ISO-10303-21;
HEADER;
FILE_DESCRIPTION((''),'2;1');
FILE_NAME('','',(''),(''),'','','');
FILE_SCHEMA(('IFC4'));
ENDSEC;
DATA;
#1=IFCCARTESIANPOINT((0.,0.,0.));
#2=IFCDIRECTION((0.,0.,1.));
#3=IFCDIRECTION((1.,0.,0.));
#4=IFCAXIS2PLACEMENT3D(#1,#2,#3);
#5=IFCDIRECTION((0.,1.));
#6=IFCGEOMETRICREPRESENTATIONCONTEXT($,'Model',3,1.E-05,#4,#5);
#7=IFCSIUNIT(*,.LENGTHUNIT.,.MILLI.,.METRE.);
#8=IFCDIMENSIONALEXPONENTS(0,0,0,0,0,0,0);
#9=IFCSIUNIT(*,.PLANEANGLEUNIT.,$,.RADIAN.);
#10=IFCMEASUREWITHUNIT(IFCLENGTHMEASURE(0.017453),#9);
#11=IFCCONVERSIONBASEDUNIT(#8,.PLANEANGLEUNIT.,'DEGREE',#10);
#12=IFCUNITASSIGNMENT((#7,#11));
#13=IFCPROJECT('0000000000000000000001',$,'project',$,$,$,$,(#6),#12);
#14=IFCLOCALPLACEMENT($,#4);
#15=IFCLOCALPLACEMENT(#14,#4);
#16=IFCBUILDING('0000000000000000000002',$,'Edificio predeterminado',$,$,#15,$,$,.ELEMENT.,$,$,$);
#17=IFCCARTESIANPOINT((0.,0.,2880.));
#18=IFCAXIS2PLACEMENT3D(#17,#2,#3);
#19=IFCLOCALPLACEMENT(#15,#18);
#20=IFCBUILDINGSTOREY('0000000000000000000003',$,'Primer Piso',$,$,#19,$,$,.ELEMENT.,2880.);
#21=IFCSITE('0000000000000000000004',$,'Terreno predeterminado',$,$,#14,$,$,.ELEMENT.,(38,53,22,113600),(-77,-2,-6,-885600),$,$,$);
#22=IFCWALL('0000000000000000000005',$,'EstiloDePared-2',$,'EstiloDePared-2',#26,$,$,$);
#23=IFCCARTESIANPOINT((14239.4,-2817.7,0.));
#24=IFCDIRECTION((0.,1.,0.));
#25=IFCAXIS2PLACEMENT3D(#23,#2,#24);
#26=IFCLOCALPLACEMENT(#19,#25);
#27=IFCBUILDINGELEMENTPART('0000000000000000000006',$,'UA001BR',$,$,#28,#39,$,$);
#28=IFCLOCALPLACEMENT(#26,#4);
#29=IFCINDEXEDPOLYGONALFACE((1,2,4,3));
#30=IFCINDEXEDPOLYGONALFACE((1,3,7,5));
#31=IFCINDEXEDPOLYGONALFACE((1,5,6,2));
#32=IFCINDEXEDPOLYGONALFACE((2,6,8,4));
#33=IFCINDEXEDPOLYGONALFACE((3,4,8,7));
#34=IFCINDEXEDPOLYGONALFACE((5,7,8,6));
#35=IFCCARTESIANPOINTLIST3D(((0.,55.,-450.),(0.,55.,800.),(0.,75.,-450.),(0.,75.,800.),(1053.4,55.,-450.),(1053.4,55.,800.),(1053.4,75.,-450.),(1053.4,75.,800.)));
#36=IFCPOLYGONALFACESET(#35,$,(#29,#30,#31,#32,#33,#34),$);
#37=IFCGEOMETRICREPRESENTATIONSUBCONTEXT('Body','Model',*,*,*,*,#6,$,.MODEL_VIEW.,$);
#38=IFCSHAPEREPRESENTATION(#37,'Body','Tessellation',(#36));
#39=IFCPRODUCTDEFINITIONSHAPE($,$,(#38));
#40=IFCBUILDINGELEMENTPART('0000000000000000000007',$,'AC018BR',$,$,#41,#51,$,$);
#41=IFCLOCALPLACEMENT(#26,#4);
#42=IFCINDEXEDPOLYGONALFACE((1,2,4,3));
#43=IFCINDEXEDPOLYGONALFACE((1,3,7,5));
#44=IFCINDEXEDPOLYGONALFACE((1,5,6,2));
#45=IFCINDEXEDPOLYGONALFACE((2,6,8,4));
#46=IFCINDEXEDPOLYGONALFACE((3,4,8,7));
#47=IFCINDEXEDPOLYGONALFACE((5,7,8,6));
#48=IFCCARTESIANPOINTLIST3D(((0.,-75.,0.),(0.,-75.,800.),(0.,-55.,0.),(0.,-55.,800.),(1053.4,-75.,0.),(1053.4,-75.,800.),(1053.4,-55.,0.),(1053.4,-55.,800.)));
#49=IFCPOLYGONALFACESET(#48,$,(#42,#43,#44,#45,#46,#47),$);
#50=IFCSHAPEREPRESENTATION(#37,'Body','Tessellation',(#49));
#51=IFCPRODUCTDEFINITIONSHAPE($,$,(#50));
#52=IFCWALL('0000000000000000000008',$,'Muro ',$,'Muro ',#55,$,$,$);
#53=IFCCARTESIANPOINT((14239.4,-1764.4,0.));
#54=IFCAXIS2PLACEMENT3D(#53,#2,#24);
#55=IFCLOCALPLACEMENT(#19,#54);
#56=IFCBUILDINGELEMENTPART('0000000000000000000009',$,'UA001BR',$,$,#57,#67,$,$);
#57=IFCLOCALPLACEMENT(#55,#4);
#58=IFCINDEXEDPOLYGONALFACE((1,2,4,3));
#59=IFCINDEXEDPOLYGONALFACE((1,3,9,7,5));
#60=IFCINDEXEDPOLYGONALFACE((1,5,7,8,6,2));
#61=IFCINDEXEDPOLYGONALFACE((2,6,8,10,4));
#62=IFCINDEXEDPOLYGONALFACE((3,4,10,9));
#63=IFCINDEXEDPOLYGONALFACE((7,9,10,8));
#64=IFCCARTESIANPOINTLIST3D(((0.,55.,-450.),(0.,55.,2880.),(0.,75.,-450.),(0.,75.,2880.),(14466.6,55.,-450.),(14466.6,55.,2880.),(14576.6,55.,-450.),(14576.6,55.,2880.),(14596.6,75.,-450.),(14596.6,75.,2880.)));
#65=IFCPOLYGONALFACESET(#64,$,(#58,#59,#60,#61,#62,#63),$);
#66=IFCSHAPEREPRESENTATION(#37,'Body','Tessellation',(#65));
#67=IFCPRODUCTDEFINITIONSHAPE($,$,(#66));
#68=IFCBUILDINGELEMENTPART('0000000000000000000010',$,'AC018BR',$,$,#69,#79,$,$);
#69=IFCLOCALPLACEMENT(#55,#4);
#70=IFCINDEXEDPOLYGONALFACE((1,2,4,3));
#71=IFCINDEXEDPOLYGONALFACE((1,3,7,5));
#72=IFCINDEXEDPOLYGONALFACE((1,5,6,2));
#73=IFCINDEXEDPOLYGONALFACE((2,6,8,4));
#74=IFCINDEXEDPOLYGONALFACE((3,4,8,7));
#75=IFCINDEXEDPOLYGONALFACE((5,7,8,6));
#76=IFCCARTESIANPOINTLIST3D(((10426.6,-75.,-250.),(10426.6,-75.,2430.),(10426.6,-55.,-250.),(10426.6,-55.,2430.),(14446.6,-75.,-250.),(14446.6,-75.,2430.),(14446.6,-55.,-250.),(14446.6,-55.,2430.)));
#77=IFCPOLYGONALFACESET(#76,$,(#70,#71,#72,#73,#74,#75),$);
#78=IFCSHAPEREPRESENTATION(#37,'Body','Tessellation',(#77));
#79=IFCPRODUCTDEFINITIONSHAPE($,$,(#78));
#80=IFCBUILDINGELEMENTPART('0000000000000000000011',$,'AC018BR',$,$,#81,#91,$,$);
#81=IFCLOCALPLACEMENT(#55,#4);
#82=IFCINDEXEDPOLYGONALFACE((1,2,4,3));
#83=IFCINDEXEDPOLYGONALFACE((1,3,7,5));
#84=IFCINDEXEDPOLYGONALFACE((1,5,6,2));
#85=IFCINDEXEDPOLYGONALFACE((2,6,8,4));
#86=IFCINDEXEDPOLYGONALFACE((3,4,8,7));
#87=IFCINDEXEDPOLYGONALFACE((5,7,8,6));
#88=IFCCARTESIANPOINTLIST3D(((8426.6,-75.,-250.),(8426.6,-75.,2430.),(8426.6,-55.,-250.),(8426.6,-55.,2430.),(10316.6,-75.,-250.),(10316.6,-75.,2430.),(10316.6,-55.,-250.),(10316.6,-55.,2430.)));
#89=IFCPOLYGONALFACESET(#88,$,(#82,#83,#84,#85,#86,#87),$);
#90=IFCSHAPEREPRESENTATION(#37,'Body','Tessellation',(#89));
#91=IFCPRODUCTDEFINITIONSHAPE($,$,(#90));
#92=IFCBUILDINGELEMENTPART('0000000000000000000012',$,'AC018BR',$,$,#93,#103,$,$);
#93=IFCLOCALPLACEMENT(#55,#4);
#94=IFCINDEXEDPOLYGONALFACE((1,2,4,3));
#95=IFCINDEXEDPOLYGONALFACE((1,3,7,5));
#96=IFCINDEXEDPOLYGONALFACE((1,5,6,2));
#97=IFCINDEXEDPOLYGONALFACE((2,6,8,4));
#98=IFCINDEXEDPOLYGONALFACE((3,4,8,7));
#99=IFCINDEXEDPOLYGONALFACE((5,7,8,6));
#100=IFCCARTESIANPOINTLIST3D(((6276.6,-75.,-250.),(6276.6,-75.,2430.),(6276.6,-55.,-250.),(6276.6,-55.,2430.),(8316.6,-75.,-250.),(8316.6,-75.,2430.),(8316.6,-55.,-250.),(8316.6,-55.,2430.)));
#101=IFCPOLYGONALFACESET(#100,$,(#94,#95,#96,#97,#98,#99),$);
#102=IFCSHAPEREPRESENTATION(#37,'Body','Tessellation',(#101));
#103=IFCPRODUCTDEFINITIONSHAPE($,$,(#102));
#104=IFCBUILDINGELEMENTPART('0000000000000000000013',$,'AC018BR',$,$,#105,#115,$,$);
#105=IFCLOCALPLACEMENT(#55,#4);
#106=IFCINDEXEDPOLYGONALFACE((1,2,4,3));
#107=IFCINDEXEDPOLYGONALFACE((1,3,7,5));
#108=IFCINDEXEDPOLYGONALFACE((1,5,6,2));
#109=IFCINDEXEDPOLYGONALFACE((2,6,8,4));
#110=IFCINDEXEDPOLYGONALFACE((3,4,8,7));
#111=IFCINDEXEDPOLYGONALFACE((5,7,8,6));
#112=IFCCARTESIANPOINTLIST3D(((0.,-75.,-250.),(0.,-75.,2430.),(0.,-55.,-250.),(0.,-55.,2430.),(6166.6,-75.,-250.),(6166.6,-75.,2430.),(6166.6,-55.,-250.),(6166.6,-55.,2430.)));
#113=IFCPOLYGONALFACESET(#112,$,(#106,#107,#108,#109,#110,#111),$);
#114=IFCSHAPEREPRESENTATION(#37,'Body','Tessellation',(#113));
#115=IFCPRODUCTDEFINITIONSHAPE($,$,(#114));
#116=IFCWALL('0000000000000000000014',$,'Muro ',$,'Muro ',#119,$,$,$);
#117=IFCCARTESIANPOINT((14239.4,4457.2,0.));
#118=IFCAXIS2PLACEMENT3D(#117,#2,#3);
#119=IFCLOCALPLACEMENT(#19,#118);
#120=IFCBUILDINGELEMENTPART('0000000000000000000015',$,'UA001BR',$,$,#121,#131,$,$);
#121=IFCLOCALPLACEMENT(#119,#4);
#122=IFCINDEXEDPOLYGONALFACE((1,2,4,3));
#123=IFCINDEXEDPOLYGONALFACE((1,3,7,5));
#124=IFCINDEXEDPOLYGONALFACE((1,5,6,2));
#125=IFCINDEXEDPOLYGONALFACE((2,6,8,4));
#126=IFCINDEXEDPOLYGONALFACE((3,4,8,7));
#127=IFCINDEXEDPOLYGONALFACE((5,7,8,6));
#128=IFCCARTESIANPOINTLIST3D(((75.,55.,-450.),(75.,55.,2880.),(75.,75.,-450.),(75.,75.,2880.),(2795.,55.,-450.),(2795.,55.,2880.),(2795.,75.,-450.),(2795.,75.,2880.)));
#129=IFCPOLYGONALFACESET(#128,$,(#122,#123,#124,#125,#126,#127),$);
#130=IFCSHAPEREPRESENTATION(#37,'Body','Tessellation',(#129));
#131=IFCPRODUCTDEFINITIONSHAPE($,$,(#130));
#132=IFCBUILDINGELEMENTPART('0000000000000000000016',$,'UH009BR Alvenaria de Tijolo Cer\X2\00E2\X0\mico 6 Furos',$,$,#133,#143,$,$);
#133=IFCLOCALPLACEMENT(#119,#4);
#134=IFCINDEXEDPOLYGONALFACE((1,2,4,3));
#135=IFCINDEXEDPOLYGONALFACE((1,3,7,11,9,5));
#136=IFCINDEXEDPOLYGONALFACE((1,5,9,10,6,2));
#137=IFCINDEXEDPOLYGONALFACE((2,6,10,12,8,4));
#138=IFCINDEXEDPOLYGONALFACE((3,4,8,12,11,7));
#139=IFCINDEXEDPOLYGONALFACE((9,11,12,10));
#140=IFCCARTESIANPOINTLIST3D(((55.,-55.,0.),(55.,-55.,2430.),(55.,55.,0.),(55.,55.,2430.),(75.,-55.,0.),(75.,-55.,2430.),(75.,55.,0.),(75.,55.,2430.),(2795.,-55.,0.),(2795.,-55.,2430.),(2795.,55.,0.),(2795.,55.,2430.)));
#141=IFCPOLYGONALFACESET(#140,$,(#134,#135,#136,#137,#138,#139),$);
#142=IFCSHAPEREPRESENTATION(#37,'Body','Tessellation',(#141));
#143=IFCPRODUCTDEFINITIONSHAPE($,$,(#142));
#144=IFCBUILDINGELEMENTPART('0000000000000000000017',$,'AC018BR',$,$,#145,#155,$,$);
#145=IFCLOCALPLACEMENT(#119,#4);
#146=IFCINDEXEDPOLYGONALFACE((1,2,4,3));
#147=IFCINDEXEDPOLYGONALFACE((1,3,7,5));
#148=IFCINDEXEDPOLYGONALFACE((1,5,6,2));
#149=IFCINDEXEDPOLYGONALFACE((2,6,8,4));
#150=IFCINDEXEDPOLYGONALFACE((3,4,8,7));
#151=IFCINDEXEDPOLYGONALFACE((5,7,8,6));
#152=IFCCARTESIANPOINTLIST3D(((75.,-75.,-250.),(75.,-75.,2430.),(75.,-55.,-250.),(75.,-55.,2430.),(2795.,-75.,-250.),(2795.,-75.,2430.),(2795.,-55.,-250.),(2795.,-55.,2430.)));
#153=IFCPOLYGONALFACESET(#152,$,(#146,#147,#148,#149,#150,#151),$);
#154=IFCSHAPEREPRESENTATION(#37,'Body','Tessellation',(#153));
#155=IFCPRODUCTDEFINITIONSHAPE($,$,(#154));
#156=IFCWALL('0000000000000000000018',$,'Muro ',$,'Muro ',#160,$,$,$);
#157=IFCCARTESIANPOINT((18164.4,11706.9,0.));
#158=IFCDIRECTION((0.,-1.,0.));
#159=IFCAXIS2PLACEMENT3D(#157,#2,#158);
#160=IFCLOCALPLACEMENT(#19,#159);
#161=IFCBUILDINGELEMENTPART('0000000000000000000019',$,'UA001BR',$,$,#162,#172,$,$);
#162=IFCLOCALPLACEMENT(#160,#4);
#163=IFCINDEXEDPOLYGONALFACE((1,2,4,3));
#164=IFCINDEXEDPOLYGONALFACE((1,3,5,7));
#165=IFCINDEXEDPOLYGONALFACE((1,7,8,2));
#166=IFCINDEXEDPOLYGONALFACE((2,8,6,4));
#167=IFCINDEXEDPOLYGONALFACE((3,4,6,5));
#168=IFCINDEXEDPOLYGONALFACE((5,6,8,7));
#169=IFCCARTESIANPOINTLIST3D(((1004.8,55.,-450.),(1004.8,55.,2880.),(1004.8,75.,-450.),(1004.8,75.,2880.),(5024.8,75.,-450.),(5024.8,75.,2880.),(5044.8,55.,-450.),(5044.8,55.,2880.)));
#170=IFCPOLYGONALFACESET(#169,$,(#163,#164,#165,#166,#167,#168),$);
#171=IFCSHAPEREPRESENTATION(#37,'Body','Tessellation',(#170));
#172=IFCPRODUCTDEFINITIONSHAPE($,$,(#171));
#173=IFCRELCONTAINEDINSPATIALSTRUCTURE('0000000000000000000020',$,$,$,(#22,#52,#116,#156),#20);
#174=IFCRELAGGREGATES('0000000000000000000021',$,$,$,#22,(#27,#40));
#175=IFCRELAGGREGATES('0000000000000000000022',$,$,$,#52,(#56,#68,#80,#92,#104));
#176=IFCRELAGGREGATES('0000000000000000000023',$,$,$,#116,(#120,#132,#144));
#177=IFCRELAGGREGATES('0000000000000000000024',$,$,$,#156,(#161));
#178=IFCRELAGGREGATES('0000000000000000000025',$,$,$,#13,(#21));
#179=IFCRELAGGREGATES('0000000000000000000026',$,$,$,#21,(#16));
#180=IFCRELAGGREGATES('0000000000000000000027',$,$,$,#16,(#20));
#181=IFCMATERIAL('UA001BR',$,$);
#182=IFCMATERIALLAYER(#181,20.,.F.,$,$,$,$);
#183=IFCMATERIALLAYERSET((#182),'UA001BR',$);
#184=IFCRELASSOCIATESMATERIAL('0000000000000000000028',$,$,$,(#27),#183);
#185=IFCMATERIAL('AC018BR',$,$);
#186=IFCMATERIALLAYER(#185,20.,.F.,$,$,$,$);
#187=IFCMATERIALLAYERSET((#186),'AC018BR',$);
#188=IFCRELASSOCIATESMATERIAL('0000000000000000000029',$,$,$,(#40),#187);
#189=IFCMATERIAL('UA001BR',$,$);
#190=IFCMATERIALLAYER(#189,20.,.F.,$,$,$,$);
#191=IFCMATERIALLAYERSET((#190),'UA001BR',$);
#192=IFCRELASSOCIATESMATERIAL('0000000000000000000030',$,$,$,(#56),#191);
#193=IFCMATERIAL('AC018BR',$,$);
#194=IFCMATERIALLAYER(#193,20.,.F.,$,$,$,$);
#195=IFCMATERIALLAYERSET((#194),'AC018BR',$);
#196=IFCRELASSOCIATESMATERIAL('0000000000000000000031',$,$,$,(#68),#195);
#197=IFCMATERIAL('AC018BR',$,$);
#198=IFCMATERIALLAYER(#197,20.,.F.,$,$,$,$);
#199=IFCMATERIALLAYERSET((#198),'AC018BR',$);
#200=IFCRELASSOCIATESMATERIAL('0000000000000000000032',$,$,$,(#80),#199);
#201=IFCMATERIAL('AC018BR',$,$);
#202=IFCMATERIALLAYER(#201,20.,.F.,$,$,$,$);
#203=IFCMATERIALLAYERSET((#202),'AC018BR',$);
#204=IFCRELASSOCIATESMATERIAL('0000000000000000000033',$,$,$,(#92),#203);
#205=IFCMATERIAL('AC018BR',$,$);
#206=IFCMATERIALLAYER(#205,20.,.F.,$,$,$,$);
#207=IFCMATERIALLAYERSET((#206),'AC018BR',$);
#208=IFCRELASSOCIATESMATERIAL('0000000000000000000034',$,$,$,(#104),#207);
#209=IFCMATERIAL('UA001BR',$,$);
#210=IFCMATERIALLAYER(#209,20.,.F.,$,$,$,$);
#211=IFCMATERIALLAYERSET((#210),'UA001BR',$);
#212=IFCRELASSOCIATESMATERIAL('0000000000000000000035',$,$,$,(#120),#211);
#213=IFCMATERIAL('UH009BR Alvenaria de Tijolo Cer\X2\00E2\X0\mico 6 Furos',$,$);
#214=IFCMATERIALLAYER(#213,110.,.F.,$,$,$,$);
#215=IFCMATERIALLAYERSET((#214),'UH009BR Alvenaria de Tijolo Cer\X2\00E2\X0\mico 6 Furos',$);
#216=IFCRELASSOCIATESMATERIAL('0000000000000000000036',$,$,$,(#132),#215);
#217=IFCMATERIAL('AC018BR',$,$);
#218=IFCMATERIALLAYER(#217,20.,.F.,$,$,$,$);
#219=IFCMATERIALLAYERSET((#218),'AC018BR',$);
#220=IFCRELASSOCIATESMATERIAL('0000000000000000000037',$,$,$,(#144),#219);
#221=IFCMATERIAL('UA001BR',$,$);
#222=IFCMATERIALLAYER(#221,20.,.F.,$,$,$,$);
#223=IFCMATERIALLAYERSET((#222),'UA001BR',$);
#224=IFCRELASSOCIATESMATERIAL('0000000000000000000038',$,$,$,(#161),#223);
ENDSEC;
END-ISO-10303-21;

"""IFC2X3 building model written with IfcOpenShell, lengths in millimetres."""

from ifc_helpers import new_model, entity, si_unit, converted_unit, direction, frame, origin_with_axes, place, context, subcontext, project, spatial, polyline, outline, extrude, material, layer, layer_set, layer_usage, element, aggregate, save


model = new_model("IFC2X3")

# Units and contexts
model_context = context("Model", 3, precision=1e-05, world=origin_with_axes(), true_north=direction((0.0, 1.0)))
body_context = subcontext(model_context, "Body", "Model", "MODEL_VIEW")
ifc_project = project(units=[si_unit("LENGTHUNIT", "METRE", prefix="MILLI"), converted_unit("PLANEANGLEUNIT", "DEGREE", entity("IfcLengthMeasure", 0.017453), si_unit("PLANEANGLEUNIT", "RADIAN"), dimensions=[0, 0, 0, 0, 0, 0, 0])], contexts=[model_context])

# Site, building, storey
site_placement = place(None, origin_with_axes())
site = spatial("IfcSite", under=ifc_project, at=site_placement, Name="Terreno predeterminado", CompositionType="ELEMENT", RefLatitude=(38, 53, 22, 113600), RefLongitude=(-77, -2, -6, -885600))
building_placement = place(site_placement, origin_with_axes())
building = spatial("IfcBuilding", under=site, at=building_placement, Name="Edificio predeterminado", CompositionType="ELEMENT")
storey_placement = place(building_placement, frame((0.0, 0.0, 2880.0), z_axis=(0.0, 0.0, 1.0), x_axis=(1.0, 0.0, 0.0)))
storey = spatial("IfcBuildingStorey", under=building, at=storey_placement, Name="Primer Piso", CompositionType="ELEMENT", Elevation=2880.0)

# Walls, building element parts
wall_1_placement = place(storey_placement, frame((14239.4, -2817.7, 0.0), z_axis=(0.0, 0.0, 1.0), x_axis=(0.0, 1.0, 0.0)))
wall_1 = element("IfcWall", 1, at=wall_1_placement, inside=storey, Name="EstiloDePared-2", ObjectType="EstiloDePared-2")
ifc_material_1 = material(Name="UA001BR")
ifc_layer_1 = layer(ifc_material_1, 20.0, ventilated=False)
ifc_layer_set_1 = layer_set([ifc_layer_1], Name="UA001BR")
ifc_layer_usage_1 = layer_usage(ifc_layer_set_1, "AXIS2", "NEGATIVE", -75.0)
building_element_part_1_placement = place(wall_1_placement, origin_with_axes())
building_element_part_1 = element("IfcBuildingElementPart", 2, at=building_element_part_1_placement, material=ifc_layer_usage_1, Name="UA001BR", context=body_context, shape_type="SweptSolid", body=[
    extrude(outline(polyline([(1053.4, 75.0), (1053.4, 55.0), (0.0, 55.0), (0.0, 75.0), (1053.4, 75.0)])), frame((0.0, 0.0, -450.0), z_axis=(0.0, 0.0, 1.0), x_axis=(1.0, 0.0, 0.0)), (0.0, 0.0, 1.0), 1250.0),
])
ifc_material_2 = material(Name="AC018BR")
ifc_layer_2 = layer(ifc_material_2, 20.0, ventilated=False)
ifc_layer_set_2 = layer_set([ifc_layer_2], Name="AC018BR")
ifc_layer_usage_2 = layer_usage(ifc_layer_set_2, "AXIS2", "NEGATIVE", 55.0)
building_element_part_2_placement = place(wall_1_placement, origin_with_axes())
building_element_part_2 = element("IfcBuildingElementPart", 3, at=building_element_part_2_placement, material=ifc_layer_usage_2, Name="AC018BR", context=body_context, shape_type="SweptSolid", body=[
    extrude(outline(polyline([(1053.4, -55.0), (1053.4, -75.0), (0.0, -75.0), (0.0, -55.0), (1053.4, -55.0)])), origin_with_axes(), (0.0, 0.0, 1.0), 800.0),
])
aggregate(wall_1, [building_element_part_1, building_element_part_2])
wall_2_placement = place(storey_placement, frame((14239.4, -1764.4, 0.0), z_axis=(0.0, 0.0, 1.0), x_axis=(0.0, 1.0, 0.0)))
wall_2 = element("IfcWall", 4, at=wall_2_placement, inside=storey, Name="Muro ", ObjectType="Muro ")
ifc_material_3 = material(Name="UA001BR")
ifc_layer_3 = layer(ifc_material_3, 20.0, ventilated=False)
ifc_layer_set_3 = layer_set([ifc_layer_3], Name="UA001BR")
ifc_layer_usage_3 = layer_usage(ifc_layer_set_3, "AXIS2", "NEGATIVE", -75.0)
building_element_part_3_placement = place(wall_2_placement, origin_with_axes())
building_element_part_3 = element("IfcBuildingElementPart", 5, at=building_element_part_3_placement, material=ifc_layer_usage_3, Name="UA001BR", context=body_context, shape_type="SweptSolid", body=[
    extrude(outline(polyline([(14596.6, 75.0), (14576.6, 55.0), (14466.6, 55.0), (0.0, 55.0), (0.0, 75.0), (14596.6, 75.0)])), frame((0.0, 0.0, -450.0), z_axis=(0.0, 0.0, 1.0), x_axis=(1.0, 0.0, 0.0)), (0.0, 0.0, 1.0), 3330.0),
])
ifc_material_4 = material(Name="AC018BR")
ifc_layer_4 = layer(ifc_material_4, 20.0, ventilated=False)
ifc_layer_set_4 = layer_set([ifc_layer_4], Name="AC018BR")
ifc_layer_usage_4 = layer_usage(ifc_layer_set_4, "AXIS2", "NEGATIVE", 55.0)
building_element_part_4_placement = place(wall_2_placement, origin_with_axes())
building_element_part_4 = element("IfcBuildingElementPart", 6, at=building_element_part_4_placement, material=ifc_layer_usage_4, Name="AC018BR", context=body_context, shape_type="SweptSolid", body=[
    extrude(outline(polyline([(14446.6, -55.0), (14446.6, -75.0), (10426.6, -75.0), (10426.6, -55.0), (14446.6, -55.0)])), frame((0.0, 0.0, -250.0), z_axis=(0.0, 0.0, 1.0), x_axis=(1.0, 0.0, 0.0)), (0.0, 0.0, 1.0), 2680.0),
])
ifc_material_5 = material(Name="AC018BR")
ifc_layer_5 = layer(ifc_material_5, 20.0, ventilated=False)
ifc_layer_set_5 = layer_set([ifc_layer_5], Name="AC018BR")
ifc_layer_usage_5 = layer_usage(ifc_layer_set_5, "AXIS2", "NEGATIVE", 55.0)
building_element_part_5_placement = place(wall_2_placement, origin_with_axes())
building_element_part_5 = element("IfcBuildingElementPart", 7, at=building_element_part_5_placement, material=ifc_layer_usage_5, Name="AC018BR", context=body_context, shape_type="SweptSolid", body=[
    extrude(outline(polyline([(10316.6, -55.0), (10316.6, -75.0), (8426.6, -75.0), (8426.6, -55.0), (10316.6, -55.0)])), frame((0.0, 0.0, -250.0), z_axis=(0.0, 0.0, 1.0), x_axis=(1.0, 0.0, 0.0)), (0.0, 0.0, 1.0), 2680.0),
])
ifc_material_6 = material(Name="AC018BR")
ifc_layer_6 = layer(ifc_material_6, 20.0, ventilated=False)
ifc_layer_set_6 = layer_set([ifc_layer_6], Name="AC018BR")
ifc_layer_usage_6 = layer_usage(ifc_layer_set_6, "AXIS2", "NEGATIVE", 55.0)
building_element_part_6_placement = place(wall_2_placement, origin_with_axes())
building_element_part_6 = element("IfcBuildingElementPart", 8, at=building_element_part_6_placement, material=ifc_layer_usage_6, Name="AC018BR", context=body_context, shape_type="SweptSolid", body=[
    extrude(outline(polyline([(8316.6, -55.0), (8316.6, -75.0), (6276.6, -75.0), (6276.6, -55.0), (8316.6, -55.0)])), frame((0.0, 0.0, -250.0), z_axis=(0.0, 0.0, 1.0), x_axis=(1.0, 0.0, 0.0)), (0.0, 0.0, 1.0), 2680.0),
])
ifc_material_7 = material(Name="AC018BR")
ifc_layer_7 = layer(ifc_material_7, 20.0, ventilated=False)
ifc_layer_set_7 = layer_set([ifc_layer_7], Name="AC018BR")
ifc_layer_usage_7 = layer_usage(ifc_layer_set_7, "AXIS2", "NEGATIVE", 55.0)
building_element_part_7_placement = place(wall_2_placement, origin_with_axes())
building_element_part_7 = element("IfcBuildingElementPart", 9, at=building_element_part_7_placement, material=ifc_layer_usage_7, Name="AC018BR", context=body_context, shape_type="SweptSolid", body=[
    extrude(outline(polyline([(6166.6, -55.0), (6166.6, -75.0), (0.0, -75.0), (0.0, -55.0), (6166.6, -55.0)])), frame((0.0, 0.0, -250.0), z_axis=(0.0, 0.0, 1.0), x_axis=(1.0, 0.0, 0.0)), (0.0, 0.0, 1.0), 2680.0),
])
aggregate(wall_2, [building_element_part_3, building_element_part_4, building_element_part_5, building_element_part_6, building_element_part_7])
wall_3_placement = place(storey_placement, frame((14239.4, 4457.2, 0.0), z_axis=(0.0, 0.0, 1.0), x_axis=(1.0, 0.0, 0.0)))
wall_3 = element("IfcWall", 10, at=wall_3_placement, inside=storey, Name="Muro ", ObjectType="Muro ")
ifc_material_8 = material(Name="UA001BR")
ifc_layer_8 = layer(ifc_material_8, 20.0, ventilated=False)
ifc_layer_set_8 = layer_set([ifc_layer_8], Name="UA001BR")
ifc_layer_usage_8 = layer_usage(ifc_layer_set_8, "AXIS2", "NEGATIVE", -75.0)
building_element_part_8_placement = place(wall_3_placement, origin_with_axes())
building_element_part_8 = element("IfcBuildingElementPart", 11, at=building_element_part_8_placement, material=ifc_layer_usage_8, Name="UA001BR", context=body_context, shape_type="SweptSolid", body=[
    extrude(outline(polyline([(2795.0, 75.0), (2795.0, 55.0), (75.0, 55.0), (75.0, 75.0), (2795.0, 75.0)])), frame((0.0, 0.0, -450.0), z_axis=(0.0, 0.0, 1.0), x_axis=(1.0, 0.0, 0.0)), (0.0, 0.0, 1.0), 3330.0),
])
ifc_material_9 = material(Name="UH009BR Alvenaria de Tijolo Cerâmico 6 Furos")
ifc_layer_9 = layer(ifc_material_9, 110.0, ventilated=False)
ifc_layer_set_9 = layer_set([ifc_layer_9], Name="UH009BR Alvenaria de Tijolo Cerâmico 6 Furos")
ifc_layer_usage_9 = layer_usage(ifc_layer_set_9, "AXIS2", "NEGATIVE", -55.0)
building_element_part_9_placement = place(wall_3_placement, origin_with_axes())
building_element_part_9 = element("IfcBuildingElementPart", 12, at=building_element_part_9_placement, material=ifc_layer_usage_9, Name="UH009BR Alvenaria de Tijolo Cerâmico 6 Furos", context=body_context, shape_type="SweptSolid", body=[
    extrude(outline(polyline([(2795.0, 55.0), (2795.0, -55.0), (75.0, -55.0), (55.0, -55.0), (55.0, 55.0), (75.0, 55.0), (2795.0, 55.0)])), origin_with_axes(), (0.0, 0.0, 1.0), 2430.0),
])
ifc_material_10 = material(Name="AC018BR")
ifc_layer_10 = layer(ifc_material_10, 20.0, ventilated=False)
ifc_layer_set_10 = layer_set([ifc_layer_10], Name="AC018BR")
ifc_layer_usage_10 = layer_usage(ifc_layer_set_10, "AXIS2", "NEGATIVE", 55.0)
building_element_part_10_placement = place(wall_3_placement, origin_with_axes())
building_element_part_10 = element("IfcBuildingElementPart", 13, at=building_element_part_10_placement, material=ifc_layer_usage_10, Name="AC018BR", context=body_context, shape_type="SweptSolid", body=[
    extrude(outline(polyline([(75.0, -55.0), (2795.0, -55.0), (2795.0, -75.0), (75.0, -75.0), (75.0, -55.0)])), frame((0.0, 0.0, -250.0), z_axis=(0.0, 0.0, 1.0), x_axis=(1.0, 0.0, 0.0)), (0.0, 0.0, 1.0), 2680.0),
])
aggregate(wall_3, [building_element_part_8, building_element_part_9, building_element_part_10])
wall_4_placement = place(storey_placement, frame((18164.4, 11706.9, 0.0), z_axis=(0.0, 0.0, 1.0), x_axis=(0.0, -1.0, 0.0)))
wall_4 = element("IfcWall", 14, at=wall_4_placement, inside=storey, Name="Muro ", ObjectType="Muro ")
ifc_material_11 = material(Name="UA001BR")
ifc_layer_11 = layer(ifc_material_11, 20.0, ventilated=False)
ifc_layer_set_11 = layer_set([ifc_layer_11], Name="UA001BR")
ifc_layer_usage_11 = layer_usage(ifc_layer_set_11, "AXIS2", "NEGATIVE", -75.0)
building_element_part_11_placement = place(wall_4_placement, origin_with_axes())
building_element_part_11 = element("IfcBuildingElementPart", 15, at=building_element_part_11_placement, material=ifc_layer_usage_11, Name="UA001BR", context=body_context, shape_type="SweptSolid", body=[
    extrude(outline(polyline([(5024.8, 75.0), (5044.8, 55.0), (1004.8, 55.0), (1004.8, 75.0), (5024.8, 75.0)])), frame((0.0, 0.0, -450.0), z_axis=(0.0, 0.0, 1.0), x_axis=(1.0, 0.0, 0.0)), (0.0, 0.0, 1.0), 3330.0),
])
aggregate(wall_4, [building_element_part_11])

save(model, "model.ifc")
